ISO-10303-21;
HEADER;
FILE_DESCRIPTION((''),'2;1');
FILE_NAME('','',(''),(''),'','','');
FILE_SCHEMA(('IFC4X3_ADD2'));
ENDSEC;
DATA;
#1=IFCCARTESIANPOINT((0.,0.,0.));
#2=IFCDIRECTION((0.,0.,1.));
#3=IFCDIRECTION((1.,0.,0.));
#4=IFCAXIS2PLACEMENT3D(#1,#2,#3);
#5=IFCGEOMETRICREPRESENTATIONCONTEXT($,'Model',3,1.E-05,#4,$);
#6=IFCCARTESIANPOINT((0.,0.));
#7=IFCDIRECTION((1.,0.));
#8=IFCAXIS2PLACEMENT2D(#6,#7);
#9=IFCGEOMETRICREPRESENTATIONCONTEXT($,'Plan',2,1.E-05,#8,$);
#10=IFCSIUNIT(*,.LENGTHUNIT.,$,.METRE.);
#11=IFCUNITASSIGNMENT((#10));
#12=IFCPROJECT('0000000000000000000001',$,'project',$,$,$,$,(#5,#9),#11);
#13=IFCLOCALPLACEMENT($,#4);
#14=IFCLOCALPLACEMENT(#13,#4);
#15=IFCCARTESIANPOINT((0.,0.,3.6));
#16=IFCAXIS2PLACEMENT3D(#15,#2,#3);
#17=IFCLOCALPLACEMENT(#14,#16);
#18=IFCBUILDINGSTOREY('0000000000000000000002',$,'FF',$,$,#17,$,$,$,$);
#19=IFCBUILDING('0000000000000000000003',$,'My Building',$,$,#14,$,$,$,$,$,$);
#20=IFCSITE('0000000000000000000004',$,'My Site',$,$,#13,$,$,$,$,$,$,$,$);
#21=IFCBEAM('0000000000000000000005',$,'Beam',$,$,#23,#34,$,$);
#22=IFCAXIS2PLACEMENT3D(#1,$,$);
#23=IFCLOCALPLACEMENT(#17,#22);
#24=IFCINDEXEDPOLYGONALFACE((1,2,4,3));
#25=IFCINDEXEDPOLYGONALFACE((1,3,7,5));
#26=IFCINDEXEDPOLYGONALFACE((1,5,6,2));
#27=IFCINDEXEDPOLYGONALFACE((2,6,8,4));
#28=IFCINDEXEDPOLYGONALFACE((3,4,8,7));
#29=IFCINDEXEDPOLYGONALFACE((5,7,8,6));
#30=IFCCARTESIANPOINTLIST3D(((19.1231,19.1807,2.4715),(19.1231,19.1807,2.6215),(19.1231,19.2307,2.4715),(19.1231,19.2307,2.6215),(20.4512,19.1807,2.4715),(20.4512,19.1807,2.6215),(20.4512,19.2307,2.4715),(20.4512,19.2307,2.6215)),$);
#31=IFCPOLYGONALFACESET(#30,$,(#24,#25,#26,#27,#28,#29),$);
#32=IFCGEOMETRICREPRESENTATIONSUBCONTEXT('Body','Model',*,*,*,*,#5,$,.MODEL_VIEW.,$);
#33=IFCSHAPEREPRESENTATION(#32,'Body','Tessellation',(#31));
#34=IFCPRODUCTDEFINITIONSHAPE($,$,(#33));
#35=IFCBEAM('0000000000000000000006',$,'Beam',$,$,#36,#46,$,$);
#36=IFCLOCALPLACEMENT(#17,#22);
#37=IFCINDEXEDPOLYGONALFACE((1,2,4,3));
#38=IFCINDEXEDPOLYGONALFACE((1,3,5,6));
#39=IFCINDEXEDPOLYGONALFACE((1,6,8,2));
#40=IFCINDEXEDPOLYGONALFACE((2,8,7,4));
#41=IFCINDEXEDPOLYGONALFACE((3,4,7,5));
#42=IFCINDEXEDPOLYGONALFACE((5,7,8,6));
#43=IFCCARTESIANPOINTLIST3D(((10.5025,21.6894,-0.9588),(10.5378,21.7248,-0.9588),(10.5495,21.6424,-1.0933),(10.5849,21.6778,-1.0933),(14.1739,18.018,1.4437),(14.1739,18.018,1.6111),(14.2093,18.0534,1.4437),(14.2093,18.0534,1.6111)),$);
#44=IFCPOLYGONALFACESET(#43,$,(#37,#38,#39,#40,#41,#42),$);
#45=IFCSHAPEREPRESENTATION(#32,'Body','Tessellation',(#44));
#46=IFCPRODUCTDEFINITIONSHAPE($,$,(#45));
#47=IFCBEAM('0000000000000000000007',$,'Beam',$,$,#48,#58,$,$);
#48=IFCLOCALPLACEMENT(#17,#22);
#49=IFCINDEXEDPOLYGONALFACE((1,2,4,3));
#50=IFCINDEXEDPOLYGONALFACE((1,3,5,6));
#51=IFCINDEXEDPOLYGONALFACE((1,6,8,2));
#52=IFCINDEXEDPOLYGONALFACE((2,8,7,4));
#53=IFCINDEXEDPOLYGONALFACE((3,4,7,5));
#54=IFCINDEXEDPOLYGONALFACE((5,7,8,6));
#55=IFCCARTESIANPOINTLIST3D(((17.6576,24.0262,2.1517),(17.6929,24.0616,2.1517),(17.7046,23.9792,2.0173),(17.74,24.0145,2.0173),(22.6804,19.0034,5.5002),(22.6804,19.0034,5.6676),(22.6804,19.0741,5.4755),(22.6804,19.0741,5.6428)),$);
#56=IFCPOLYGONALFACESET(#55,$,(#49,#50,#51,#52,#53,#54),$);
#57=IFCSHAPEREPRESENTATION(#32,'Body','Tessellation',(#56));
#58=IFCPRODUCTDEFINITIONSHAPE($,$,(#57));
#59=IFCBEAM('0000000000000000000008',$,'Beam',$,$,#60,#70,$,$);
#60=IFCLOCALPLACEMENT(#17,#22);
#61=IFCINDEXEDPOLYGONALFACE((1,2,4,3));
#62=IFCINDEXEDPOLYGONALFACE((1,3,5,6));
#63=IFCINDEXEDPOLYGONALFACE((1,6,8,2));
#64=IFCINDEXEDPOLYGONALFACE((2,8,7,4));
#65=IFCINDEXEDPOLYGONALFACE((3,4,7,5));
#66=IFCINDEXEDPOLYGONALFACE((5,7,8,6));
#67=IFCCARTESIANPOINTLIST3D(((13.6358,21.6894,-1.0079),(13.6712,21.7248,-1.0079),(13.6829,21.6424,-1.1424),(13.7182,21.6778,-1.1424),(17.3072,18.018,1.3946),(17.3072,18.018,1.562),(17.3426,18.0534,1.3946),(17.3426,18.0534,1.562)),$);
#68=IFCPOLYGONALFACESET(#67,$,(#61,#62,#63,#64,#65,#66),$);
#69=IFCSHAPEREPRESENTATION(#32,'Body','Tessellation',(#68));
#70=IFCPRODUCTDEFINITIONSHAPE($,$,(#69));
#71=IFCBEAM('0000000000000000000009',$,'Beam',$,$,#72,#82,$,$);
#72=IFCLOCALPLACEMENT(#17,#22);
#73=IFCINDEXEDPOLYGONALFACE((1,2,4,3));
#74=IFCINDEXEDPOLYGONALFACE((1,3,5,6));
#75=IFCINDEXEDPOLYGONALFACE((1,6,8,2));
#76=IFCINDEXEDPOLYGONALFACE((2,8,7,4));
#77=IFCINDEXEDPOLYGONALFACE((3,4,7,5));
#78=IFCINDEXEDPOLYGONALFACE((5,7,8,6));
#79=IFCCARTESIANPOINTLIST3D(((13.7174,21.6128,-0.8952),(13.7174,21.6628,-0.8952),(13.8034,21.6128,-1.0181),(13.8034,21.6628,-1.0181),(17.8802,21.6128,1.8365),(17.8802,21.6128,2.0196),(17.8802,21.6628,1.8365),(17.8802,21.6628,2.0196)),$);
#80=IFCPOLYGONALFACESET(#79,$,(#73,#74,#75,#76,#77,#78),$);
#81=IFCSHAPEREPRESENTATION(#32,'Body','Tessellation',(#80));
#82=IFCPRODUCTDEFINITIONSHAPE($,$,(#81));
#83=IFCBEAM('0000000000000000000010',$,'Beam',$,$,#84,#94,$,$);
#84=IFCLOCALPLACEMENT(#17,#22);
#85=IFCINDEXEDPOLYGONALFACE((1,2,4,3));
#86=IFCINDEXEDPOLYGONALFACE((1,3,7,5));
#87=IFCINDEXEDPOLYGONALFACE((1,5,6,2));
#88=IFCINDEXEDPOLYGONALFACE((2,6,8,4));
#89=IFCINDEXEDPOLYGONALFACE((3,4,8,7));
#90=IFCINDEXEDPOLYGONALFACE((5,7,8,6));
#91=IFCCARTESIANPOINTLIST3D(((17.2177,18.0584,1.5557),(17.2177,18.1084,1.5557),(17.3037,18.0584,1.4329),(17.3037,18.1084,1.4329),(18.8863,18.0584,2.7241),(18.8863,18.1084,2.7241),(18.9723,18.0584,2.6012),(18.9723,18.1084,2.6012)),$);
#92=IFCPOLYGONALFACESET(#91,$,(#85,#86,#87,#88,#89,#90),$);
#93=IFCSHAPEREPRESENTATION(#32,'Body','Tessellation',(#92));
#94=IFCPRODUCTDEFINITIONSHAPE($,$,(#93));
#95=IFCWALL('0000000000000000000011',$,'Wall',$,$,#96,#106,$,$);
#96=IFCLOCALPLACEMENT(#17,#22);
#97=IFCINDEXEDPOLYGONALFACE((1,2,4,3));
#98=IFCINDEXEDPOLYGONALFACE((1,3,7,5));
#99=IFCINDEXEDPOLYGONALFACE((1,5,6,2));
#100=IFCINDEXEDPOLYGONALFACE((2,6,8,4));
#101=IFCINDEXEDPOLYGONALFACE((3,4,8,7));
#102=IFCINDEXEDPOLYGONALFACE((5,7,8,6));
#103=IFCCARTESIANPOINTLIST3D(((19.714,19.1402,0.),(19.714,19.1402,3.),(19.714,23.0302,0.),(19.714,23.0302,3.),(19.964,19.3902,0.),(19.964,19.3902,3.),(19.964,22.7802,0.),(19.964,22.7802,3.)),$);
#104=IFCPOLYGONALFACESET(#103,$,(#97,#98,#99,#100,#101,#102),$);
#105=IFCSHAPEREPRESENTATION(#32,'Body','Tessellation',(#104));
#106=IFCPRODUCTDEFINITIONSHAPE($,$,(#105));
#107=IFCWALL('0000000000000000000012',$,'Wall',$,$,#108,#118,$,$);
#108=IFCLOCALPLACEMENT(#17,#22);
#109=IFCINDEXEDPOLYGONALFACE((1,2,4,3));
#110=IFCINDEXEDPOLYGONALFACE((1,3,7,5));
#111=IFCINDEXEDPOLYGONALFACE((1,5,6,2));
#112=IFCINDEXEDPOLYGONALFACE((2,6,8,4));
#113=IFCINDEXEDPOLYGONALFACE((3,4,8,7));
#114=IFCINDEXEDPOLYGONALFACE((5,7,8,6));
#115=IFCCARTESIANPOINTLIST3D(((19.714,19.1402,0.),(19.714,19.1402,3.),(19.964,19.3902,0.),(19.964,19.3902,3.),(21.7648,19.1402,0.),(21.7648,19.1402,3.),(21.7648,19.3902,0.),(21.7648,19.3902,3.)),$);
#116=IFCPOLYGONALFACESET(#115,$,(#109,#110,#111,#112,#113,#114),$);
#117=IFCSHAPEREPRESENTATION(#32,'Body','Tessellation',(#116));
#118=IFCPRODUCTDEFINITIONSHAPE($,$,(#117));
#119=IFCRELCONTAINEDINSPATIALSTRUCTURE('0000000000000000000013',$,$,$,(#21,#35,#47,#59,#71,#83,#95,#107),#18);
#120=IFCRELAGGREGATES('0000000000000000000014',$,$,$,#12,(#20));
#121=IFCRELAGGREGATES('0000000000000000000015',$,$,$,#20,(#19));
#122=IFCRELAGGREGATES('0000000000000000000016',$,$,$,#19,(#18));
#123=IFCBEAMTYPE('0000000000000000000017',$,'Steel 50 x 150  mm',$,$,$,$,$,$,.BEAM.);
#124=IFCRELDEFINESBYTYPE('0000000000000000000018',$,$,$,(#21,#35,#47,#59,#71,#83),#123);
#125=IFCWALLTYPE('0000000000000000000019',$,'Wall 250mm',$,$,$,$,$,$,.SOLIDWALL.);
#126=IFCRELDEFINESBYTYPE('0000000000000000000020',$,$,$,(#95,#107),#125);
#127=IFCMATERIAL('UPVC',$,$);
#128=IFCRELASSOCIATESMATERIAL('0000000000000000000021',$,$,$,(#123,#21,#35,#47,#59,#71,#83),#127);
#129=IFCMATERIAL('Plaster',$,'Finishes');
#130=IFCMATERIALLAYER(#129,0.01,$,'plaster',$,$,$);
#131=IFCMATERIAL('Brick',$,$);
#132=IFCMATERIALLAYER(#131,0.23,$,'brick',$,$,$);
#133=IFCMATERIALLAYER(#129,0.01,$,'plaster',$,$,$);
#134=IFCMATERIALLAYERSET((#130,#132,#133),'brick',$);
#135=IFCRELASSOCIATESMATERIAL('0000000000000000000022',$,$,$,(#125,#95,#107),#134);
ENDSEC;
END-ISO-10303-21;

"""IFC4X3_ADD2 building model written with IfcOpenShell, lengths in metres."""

from ifc_helpers import new_model, si_unit, frame, origin_with_axes, origin_2d_with_axis, place, context, subcontext, project, spatial, line, indexed_curve, rectangle, outline, extrude, clip, halfspace, material, layer, layer_set, layer_usage, material_profile, profile_set, profile_usage, type_object, element, save


model = new_model("IFC4X3_ADD2")

# Units and contexts
model_context = context("Model", 3, precision=1e-05, world=origin_with_axes())
plan_context = context("Plan", 2, precision=1e-05, world=origin_2d_with_axis())
body_context_1 = subcontext(model_context, "Body", "Model", "MODEL_VIEW")
ifc_project = project(units=[si_unit("LENGTHUNIT", "METRE")], contexts=[model_context, plan_context])

# Site, building, storey
site_placement = place(None, origin_with_axes())
site = spatial("IfcSite", under=ifc_project, at=site_placement, Name="My Site")
building_placement = place(site_placement, origin_with_axes())
building = spatial("IfcBuilding", under=site, at=building_placement, Name="My Building")
storey_placement = place(building_placement, frame((0.0, 0.0, 3.6), z_axis=(0.0, 0.0, 1.0), x_axis=(1.0, 0.0, 0.0)))
storey = spatial("IfcBuildingStorey", under=building, at=storey_placement, Name="FF")

# Beams
ifc_material_1 = material(Name="UPVC")
ifc_material_profile = material_profile(ifc_material_1, rectangle(XDim=0.05, YDim=0.15))
ifc_profile_set = profile_set([ifc_material_profile])
ifc_profile_usage_1 = profile_usage(ifc_profile_set)
beam_type = type_object("IfcBeamType", Name="Steel 50 x 150  mm", PredefinedType="BEAM", material=ifc_profile_set)
beam_1_placement = place(storey_placement, frame((19.1231, 19.2057, 2.5465), z_axis=(1.0, 0.0, 0.0), x_axis=(0.0, 1.0, 0.0)))
element("IfcBeam", 1, at=beam_1_placement, inside=storey, type_object=beam_type, material=ifc_profile_usage_1, Name="Beam", context=body_context_1, shape_type="SweptSolid", body=[
    extrude(rectangle(XDim=0.05, YDim=0.15), origin_with_axes(), (0.0, 0.0, 1.0), 1.3281),
])
ifc_profile_usage_2 = profile_usage(ifc_profile_set)
beam_2_placement = place(storey_placement, frame((10.5437, 21.6836, -1.0261), z_axis=(0.633729, -0.63373, 0.443593), x_axis=(0.707107, 0.707106, 0.0)))
element("IfcBeam", 2, at=beam_2_placement, inside=storey, type_object=beam_type, material=ifc_profile_usage_2, Name="Beam", context=body_context_1, shape_type="Clipping", body=[
    clip(extrude(rectangle(XDim=0.05, YDim=0.15), origin_with_axes(), (0.0, 0.0, 1.0), 5.9063), halfspace(frame((-5.1467, -2.2885, 4.6236), z_axis=(0.0, -0.443593, 0.896229), x_axis=(-1.0, 0.0, 0.0)), False)),
])
ifc_profile_usage_3 = profile_usage(ifc_profile_set)
beam_3_placement = place(storey_placement, frame((17.6988, 24.0204, 2.0845), z_axis=(0.633729, -0.633729, 0.443593), x_axis=(0.707107, 0.707107, 0.0)))
element("IfcBeam", 3, at=beam_3_placement, inside=storey, type_object=beam_type, material=ifc_profile_usage_3, Name="Beam", context=body_context_1, shape_type="Clipping", body=[
    clip(extrude(rectangle(XDim=0.05, YDim=0.15), origin_with_axes(), (0.0, 0.0, 1.0), 8.0387), halfspace(frame((-0.025, -8.2743, 3.7933), z_axis=(0.707107, -0.313667, 0.633729), x_axis=(-0.405488, -0.9141, 0.0)), False)),
])
ifc_profile_usage_4 = profile_usage(ifc_profile_set)
beam_4_placement = place(storey_placement, frame((13.677, 21.6836, -1.0752), z_axis=(0.633729, -0.63373, 0.443593), x_axis=(0.707107, 0.707106, 0.0)))
element("IfcBeam", 4, at=beam_4_placement, inside=storey, type_object=beam_type, material=ifc_profile_usage_4, Name="Beam", context=body_context_1, shape_type="Clipping", body=[
    clip(extrude(rectangle(XDim=0.05, YDim=0.15), origin_with_axes(), (0.0, 0.0, 1.0), 5.9063), halfspace(frame((-5.1467, -2.2885, 4.6236), z_axis=(0.0, -0.443593, 0.896229), x_axis=(-1.0, 0.0, 0.0)), False)),
])
ifc_profile_usage_5 = profile_usage(ifc_profile_set)
beam_5_placement = place(storey_placement, frame((13.7604, 21.6378, -0.9566), z_axis=(0.819152, 0.0, 0.573576), x_axis=(0.000001, 1.0, 0.0)))
element("IfcBeam", 5, at=beam_5_placement, inside=storey, type_object=beam_type, material=ifc_profile_usage_5, Name="Beam", context=body_context_1, shape_type="Clipping", body=[
    clip(extrude(rectangle(XDim=0.05, YDim=0.15), origin_with_axes(), (0.0, 0.0, 1.0), 5.1793), halfspace(frame((-10.9369, 0.1639, 5.1441), z_axis=(0.0, -0.573577, 0.819152), x_axis=(-1.0, -0.000001, 0.0)), False)),
])
ifc_profile_usage_6 = profile_usage(ifc_profile_set)
beam_6_placement = place(storey_placement, frame((17.2607, 18.0834, 1.4943), z_axis=(0.819152, 0.0, 0.573576), x_axis=(0.000001, 1.0, 0.0)))
element("IfcBeam", 6, at=beam_6_placement, inside=storey, type_object=beam_type, material=ifc_profile_usage_6, Name="Beam", context=body_context_1, shape_type="SweptSolid", body=[
    extrude(rectangle(XDim=0.05, YDim=0.15), origin_with_axes(), (0.0, 0.0, 1.0), 2.0369),
])

# Walls
ifc_material_2 = material(Name="Plaster", Category="Finishes")
ifc_layer_1 = layer(ifc_material_2, 0.01, Name="plaster")
ifc_material_3 = material(Name="Brick")
ifc_layer_2 = layer(ifc_material_3, 0.23, Name="brick")
ifc_layer_3 = layer(ifc_material_2, 0.01, Name="plaster")
ifc_layer_set_1 = layer_set([ifc_layer_1, ifc_layer_2, ifc_layer_3], Name="brick")
ifc_layer_usage_1 = layer_usage(ifc_layer_set_1, "AXIS2", "NEGATIVE", 0.0)
wall_type_1 = type_object("IfcWallType", Name="Wall 250mm", PredefinedType="SOLIDWALL", material=ifc_layer_set_1)
wall_1_placement = place(storey_placement, frame((19.714, 19.1402, 0.0), z_axis=(0.0, 0.0, 1.0), x_axis=(0.000001, 1.0, 0.0)))
element("IfcWall", 7, at=wall_1_placement, inside=storey, type_object=wall_type_1, material=ifc_layer_usage_1, Name="Wall", context=body_context_1, shape_type="SweptSolid", body=[
    extrude(outline(indexed_curve([(0.25, -0.25), (0.0, 0.0), (3.89, 0.0), (3.64, -0.25)], segments=[line(1, 2, 3, 4, 1)])), origin_with_axes(), (0.0, 0.0, 1.0), 3.0),
])
ifc_layer_usage_2 = layer_usage(ifc_layer_set_1, "AXIS2", "NEGATIVE", 0.0)
wall_2_placement = place(storey_placement, frame((21.7648, 19.1402, 0.0), z_axis=(0.0, 0.0, 1.0), x_axis=(-1.0, 0.0, 0.0)))
element("IfcWall", 8, at=wall_2_placement, inside=storey, type_object=wall_type_1, material=ifc_layer_usage_2, Name="Wall", context=body_context_1, shape_type="SweptSolid", body=[
    extrude(outline(indexed_curve([(0.0, -0.25), (0.0, 0.0), (2.0508, 0.0), (1.8008, -0.25)], segments=[line(1, 2, 3, 4, 1)])), origin_with_axes(), (0.0, 0.0, 1.0), 3.0),
])

save(model, "model.ifc")
